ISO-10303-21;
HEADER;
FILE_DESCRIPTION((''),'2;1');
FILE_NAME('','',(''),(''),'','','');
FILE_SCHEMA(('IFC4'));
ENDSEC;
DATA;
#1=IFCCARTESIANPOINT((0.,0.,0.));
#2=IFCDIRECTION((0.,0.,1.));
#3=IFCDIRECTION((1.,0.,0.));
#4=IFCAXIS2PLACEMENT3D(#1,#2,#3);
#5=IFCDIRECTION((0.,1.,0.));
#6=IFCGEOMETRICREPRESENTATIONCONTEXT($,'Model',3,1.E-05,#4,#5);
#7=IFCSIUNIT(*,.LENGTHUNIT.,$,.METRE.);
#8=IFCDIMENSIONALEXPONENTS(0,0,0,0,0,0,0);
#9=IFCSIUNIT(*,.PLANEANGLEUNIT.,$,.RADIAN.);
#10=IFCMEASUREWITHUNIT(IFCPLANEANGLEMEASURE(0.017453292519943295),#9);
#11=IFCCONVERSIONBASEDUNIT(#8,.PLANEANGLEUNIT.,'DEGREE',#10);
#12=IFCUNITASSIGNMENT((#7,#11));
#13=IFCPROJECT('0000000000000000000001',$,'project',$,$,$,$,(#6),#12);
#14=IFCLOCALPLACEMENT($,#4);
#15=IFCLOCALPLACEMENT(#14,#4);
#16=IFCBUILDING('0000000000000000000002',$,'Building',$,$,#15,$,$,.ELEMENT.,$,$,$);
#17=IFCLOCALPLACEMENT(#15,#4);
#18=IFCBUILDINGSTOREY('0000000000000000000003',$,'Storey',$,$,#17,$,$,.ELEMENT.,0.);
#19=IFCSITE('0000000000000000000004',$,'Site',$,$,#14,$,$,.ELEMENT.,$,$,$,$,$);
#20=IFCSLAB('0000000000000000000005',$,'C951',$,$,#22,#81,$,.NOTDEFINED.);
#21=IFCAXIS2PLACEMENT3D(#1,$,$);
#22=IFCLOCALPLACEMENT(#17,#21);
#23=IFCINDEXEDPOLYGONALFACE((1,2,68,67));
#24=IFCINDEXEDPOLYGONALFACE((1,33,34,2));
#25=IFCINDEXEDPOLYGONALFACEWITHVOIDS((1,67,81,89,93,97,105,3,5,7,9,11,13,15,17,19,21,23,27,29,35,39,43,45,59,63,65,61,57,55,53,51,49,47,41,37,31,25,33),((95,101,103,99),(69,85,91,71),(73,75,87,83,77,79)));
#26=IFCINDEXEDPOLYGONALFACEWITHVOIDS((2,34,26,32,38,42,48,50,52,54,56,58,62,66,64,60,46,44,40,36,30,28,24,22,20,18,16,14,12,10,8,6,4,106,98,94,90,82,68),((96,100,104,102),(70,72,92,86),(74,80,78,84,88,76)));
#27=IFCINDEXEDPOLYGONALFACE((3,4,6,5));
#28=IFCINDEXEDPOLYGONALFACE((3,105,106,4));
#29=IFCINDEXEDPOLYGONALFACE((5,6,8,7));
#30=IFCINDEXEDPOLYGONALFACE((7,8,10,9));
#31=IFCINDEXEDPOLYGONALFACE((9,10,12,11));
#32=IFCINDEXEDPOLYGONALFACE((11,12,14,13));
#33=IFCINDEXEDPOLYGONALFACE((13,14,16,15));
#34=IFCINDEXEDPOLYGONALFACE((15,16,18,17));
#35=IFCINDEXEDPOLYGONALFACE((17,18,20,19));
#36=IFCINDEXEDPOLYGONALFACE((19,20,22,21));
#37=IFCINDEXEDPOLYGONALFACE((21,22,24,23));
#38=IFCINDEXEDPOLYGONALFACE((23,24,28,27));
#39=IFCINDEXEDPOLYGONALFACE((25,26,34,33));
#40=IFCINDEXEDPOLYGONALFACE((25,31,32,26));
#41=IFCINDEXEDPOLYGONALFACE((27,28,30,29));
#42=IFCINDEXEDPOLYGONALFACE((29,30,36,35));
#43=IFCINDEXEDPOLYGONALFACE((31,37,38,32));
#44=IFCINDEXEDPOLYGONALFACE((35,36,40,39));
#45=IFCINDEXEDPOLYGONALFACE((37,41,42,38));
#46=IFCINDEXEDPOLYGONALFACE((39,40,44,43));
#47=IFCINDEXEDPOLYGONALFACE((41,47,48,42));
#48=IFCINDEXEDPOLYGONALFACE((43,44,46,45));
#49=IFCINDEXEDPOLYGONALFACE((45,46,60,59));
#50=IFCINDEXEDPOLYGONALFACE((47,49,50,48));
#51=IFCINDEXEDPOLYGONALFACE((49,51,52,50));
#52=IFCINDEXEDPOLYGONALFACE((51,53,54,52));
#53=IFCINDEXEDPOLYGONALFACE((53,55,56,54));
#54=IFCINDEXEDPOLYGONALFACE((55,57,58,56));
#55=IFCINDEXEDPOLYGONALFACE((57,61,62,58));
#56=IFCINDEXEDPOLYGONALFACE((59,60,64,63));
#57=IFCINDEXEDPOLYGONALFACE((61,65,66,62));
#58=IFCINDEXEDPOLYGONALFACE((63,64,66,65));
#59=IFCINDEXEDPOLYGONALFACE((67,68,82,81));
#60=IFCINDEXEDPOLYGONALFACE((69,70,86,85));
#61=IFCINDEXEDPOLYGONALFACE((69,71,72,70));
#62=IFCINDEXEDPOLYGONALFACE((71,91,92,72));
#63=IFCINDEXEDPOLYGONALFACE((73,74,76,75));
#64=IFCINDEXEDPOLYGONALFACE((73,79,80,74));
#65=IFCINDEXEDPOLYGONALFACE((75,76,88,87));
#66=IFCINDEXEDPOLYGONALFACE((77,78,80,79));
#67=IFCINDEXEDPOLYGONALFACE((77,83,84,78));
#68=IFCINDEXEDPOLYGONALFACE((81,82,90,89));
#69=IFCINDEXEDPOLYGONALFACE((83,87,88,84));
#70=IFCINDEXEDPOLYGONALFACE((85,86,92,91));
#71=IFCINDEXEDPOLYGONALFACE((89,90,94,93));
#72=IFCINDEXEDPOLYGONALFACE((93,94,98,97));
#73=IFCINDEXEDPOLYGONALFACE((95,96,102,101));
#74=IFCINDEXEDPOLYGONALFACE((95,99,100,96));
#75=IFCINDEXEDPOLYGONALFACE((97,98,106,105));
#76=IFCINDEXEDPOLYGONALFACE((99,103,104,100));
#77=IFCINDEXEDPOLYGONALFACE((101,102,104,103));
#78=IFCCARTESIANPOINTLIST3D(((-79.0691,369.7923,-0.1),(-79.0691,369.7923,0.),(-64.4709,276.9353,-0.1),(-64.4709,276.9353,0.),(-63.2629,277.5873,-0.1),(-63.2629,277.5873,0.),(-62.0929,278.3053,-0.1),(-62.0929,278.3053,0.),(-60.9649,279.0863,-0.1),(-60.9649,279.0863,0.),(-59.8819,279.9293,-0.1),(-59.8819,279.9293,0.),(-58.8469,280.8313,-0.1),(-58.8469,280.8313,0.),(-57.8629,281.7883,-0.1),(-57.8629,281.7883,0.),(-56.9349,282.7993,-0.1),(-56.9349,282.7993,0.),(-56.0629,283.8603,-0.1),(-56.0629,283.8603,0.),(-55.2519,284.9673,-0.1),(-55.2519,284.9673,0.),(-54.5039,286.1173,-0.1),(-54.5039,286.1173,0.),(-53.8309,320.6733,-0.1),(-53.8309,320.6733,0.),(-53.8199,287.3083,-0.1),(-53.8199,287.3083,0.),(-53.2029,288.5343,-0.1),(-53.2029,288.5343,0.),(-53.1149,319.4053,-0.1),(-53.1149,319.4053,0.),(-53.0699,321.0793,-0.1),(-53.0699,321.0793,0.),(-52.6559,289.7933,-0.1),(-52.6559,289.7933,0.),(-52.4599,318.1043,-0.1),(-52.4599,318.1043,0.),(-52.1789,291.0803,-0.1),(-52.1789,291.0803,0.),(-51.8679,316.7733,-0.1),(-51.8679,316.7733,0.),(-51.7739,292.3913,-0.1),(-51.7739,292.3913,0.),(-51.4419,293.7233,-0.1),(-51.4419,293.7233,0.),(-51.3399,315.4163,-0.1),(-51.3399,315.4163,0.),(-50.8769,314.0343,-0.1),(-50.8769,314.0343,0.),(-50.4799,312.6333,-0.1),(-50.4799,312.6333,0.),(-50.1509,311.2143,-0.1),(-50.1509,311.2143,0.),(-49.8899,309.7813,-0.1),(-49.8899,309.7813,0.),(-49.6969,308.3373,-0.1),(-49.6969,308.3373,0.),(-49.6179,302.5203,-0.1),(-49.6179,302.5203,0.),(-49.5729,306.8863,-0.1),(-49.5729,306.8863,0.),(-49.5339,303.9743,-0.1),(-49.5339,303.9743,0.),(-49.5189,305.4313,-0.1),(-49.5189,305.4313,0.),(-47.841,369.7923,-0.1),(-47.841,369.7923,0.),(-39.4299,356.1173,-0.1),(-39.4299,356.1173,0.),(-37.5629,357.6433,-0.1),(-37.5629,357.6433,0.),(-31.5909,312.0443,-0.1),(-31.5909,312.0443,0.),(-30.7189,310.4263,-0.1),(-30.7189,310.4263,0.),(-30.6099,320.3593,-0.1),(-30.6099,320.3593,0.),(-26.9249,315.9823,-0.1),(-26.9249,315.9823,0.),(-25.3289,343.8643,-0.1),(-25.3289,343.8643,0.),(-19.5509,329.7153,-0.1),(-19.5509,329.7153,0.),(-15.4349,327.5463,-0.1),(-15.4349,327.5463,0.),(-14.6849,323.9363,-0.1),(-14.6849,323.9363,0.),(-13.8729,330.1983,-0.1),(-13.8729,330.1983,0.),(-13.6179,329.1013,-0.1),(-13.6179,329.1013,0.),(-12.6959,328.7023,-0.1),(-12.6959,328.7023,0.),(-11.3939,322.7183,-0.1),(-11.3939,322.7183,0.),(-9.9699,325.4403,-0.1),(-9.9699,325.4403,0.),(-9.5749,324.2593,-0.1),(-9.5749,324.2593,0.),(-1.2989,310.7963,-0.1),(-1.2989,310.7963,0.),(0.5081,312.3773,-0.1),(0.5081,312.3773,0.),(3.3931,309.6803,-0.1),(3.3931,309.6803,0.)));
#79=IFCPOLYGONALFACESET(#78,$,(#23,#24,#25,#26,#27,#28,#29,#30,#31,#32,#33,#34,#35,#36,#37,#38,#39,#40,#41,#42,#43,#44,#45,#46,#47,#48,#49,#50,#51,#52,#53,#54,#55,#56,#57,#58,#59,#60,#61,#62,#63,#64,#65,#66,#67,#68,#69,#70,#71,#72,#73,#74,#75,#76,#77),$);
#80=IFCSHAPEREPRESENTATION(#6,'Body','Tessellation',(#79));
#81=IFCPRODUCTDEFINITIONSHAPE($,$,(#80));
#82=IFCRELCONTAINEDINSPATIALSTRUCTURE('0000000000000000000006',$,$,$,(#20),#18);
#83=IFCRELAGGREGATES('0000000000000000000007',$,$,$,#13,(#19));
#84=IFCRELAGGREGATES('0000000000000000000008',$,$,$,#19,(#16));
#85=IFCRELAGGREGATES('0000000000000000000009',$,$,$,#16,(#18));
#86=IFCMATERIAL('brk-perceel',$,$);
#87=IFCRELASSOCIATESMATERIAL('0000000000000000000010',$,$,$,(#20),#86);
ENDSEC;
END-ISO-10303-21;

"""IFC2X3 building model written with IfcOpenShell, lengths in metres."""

from ifc_helpers import new_model, entity, si_unit, converted_unit, direction, frame, origin_with_axes, place, context, project, spatial, polyline, outline, extrude, material, element, save


model = new_model("IFC2X3")

# Units and contexts
model_context = context("Model", 3, precision=1e-05, world=origin_with_axes(), true_north=direction((0.0, 1.0, 0.0)))
ifc_project = project(units=[si_unit("LENGTHUNIT", "METRE"), converted_unit("PLANEANGLEUNIT", "DEGREE", entity("IfcPlaneAngleMeasure", 0.017453292519943295), si_unit("PLANEANGLEUNIT", "RADIAN"), dimensions=[0, 0, 0, 0, 0, 0, 0])], contexts=[model_context])

# Site, building, storey
site_placement = place(None, origin_with_axes())
site = spatial("IfcSite", under=ifc_project, at=site_placement, Name="Site", CompositionType="ELEMENT")
building_placement = place(site_placement, origin_with_axes())
building = spatial("IfcBuilding", under=site, at=building_placement, Name="Building", CompositionType="ELEMENT")
storey_placement = place(building_placement, origin_with_axes())
storey = spatial("IfcBuildingStorey", under=building, at=storey_placement, Name="Storey", CompositionType="ELEMENT", Elevation=0.0)

# Slab
ifc_material = material(Name="brk-perceel")
slab_1_placement = place(storey_placement, frame((0.0, 0.0, -0.1), z_axis=(0.0, 0.0, 1.0), x_axis=(1.0, 0.0, 0.0)))
element("IfcSlab", 1, at=slab_1_placement, inside=storey, material=ifc_material, Name="C951", PredefinedType="NOTDEFINED", context=model_context, shape_type="SweptSolid", body=[
    extrude(outline(polyline([(-25.3289, 343.8643), (-13.8729, 330.1983), (-12.6959, 328.7023), (-9.9699, 325.4403), (3.3931, 309.6803), (-64.4709, 276.9353), (-63.2629, 277.5873), (-62.0929, 278.3053), (-60.9649, 279.0863), (-59.8819, 279.9293), (-58.8469, 280.8313), (-57.8629, 281.7883), (-56.9349, 282.7993), (-56.0629, 283.8603), (-55.2519, 284.9673), (-54.5039, 286.1173), (-53.8199, 287.3083), (-53.2029, 288.5343), (-52.6559, 289.7933), (-52.1789, 291.0803), (-51.7739, 292.3913), (-51.4419, 293.7233), (-49.6179, 302.5203), (-49.5339, 303.9743), (-49.5189, 305.4313), (-49.5729, 306.8863), (-49.6969, 308.3373), (-49.8899, 309.7813), (-50.1509, 311.2143), (-50.4799, 312.6333), (-50.8769, 314.0343), (-51.3399, 315.4163), (-51.8679, 316.7733), (-52.4599, 318.1043), (-53.1149, 319.4053), (-53.8309, 320.6733), (-53.0699, 321.0793), (-79.0691, 369.7923), (-47.841, 369.7923), (-25.3289, 343.8643)]), holes=[polyline([(-1.2989, 310.7963), (0.5081, 312.3773), (-9.5749, 324.2593), (-11.3939, 322.7183), (-1.2989, 310.7963)]), polyline([(-15.4349, 327.5463), (-13.6179, 329.1013), (-37.5629, 357.6433), (-39.4299, 356.1173), (-15.4349, 327.5463)]), polyline([(-14.6849, 323.9363), (-19.5509, 329.7153), (-30.6099, 320.3593), (-26.9249, 315.9823), (-31.5909, 312.0443), (-30.7189, 310.4263), (-14.6849, 323.9363)])]), origin_with_axes(), (0.0, 0.0, 1.0), 0.1),
])

save(model, "model.ifc")
